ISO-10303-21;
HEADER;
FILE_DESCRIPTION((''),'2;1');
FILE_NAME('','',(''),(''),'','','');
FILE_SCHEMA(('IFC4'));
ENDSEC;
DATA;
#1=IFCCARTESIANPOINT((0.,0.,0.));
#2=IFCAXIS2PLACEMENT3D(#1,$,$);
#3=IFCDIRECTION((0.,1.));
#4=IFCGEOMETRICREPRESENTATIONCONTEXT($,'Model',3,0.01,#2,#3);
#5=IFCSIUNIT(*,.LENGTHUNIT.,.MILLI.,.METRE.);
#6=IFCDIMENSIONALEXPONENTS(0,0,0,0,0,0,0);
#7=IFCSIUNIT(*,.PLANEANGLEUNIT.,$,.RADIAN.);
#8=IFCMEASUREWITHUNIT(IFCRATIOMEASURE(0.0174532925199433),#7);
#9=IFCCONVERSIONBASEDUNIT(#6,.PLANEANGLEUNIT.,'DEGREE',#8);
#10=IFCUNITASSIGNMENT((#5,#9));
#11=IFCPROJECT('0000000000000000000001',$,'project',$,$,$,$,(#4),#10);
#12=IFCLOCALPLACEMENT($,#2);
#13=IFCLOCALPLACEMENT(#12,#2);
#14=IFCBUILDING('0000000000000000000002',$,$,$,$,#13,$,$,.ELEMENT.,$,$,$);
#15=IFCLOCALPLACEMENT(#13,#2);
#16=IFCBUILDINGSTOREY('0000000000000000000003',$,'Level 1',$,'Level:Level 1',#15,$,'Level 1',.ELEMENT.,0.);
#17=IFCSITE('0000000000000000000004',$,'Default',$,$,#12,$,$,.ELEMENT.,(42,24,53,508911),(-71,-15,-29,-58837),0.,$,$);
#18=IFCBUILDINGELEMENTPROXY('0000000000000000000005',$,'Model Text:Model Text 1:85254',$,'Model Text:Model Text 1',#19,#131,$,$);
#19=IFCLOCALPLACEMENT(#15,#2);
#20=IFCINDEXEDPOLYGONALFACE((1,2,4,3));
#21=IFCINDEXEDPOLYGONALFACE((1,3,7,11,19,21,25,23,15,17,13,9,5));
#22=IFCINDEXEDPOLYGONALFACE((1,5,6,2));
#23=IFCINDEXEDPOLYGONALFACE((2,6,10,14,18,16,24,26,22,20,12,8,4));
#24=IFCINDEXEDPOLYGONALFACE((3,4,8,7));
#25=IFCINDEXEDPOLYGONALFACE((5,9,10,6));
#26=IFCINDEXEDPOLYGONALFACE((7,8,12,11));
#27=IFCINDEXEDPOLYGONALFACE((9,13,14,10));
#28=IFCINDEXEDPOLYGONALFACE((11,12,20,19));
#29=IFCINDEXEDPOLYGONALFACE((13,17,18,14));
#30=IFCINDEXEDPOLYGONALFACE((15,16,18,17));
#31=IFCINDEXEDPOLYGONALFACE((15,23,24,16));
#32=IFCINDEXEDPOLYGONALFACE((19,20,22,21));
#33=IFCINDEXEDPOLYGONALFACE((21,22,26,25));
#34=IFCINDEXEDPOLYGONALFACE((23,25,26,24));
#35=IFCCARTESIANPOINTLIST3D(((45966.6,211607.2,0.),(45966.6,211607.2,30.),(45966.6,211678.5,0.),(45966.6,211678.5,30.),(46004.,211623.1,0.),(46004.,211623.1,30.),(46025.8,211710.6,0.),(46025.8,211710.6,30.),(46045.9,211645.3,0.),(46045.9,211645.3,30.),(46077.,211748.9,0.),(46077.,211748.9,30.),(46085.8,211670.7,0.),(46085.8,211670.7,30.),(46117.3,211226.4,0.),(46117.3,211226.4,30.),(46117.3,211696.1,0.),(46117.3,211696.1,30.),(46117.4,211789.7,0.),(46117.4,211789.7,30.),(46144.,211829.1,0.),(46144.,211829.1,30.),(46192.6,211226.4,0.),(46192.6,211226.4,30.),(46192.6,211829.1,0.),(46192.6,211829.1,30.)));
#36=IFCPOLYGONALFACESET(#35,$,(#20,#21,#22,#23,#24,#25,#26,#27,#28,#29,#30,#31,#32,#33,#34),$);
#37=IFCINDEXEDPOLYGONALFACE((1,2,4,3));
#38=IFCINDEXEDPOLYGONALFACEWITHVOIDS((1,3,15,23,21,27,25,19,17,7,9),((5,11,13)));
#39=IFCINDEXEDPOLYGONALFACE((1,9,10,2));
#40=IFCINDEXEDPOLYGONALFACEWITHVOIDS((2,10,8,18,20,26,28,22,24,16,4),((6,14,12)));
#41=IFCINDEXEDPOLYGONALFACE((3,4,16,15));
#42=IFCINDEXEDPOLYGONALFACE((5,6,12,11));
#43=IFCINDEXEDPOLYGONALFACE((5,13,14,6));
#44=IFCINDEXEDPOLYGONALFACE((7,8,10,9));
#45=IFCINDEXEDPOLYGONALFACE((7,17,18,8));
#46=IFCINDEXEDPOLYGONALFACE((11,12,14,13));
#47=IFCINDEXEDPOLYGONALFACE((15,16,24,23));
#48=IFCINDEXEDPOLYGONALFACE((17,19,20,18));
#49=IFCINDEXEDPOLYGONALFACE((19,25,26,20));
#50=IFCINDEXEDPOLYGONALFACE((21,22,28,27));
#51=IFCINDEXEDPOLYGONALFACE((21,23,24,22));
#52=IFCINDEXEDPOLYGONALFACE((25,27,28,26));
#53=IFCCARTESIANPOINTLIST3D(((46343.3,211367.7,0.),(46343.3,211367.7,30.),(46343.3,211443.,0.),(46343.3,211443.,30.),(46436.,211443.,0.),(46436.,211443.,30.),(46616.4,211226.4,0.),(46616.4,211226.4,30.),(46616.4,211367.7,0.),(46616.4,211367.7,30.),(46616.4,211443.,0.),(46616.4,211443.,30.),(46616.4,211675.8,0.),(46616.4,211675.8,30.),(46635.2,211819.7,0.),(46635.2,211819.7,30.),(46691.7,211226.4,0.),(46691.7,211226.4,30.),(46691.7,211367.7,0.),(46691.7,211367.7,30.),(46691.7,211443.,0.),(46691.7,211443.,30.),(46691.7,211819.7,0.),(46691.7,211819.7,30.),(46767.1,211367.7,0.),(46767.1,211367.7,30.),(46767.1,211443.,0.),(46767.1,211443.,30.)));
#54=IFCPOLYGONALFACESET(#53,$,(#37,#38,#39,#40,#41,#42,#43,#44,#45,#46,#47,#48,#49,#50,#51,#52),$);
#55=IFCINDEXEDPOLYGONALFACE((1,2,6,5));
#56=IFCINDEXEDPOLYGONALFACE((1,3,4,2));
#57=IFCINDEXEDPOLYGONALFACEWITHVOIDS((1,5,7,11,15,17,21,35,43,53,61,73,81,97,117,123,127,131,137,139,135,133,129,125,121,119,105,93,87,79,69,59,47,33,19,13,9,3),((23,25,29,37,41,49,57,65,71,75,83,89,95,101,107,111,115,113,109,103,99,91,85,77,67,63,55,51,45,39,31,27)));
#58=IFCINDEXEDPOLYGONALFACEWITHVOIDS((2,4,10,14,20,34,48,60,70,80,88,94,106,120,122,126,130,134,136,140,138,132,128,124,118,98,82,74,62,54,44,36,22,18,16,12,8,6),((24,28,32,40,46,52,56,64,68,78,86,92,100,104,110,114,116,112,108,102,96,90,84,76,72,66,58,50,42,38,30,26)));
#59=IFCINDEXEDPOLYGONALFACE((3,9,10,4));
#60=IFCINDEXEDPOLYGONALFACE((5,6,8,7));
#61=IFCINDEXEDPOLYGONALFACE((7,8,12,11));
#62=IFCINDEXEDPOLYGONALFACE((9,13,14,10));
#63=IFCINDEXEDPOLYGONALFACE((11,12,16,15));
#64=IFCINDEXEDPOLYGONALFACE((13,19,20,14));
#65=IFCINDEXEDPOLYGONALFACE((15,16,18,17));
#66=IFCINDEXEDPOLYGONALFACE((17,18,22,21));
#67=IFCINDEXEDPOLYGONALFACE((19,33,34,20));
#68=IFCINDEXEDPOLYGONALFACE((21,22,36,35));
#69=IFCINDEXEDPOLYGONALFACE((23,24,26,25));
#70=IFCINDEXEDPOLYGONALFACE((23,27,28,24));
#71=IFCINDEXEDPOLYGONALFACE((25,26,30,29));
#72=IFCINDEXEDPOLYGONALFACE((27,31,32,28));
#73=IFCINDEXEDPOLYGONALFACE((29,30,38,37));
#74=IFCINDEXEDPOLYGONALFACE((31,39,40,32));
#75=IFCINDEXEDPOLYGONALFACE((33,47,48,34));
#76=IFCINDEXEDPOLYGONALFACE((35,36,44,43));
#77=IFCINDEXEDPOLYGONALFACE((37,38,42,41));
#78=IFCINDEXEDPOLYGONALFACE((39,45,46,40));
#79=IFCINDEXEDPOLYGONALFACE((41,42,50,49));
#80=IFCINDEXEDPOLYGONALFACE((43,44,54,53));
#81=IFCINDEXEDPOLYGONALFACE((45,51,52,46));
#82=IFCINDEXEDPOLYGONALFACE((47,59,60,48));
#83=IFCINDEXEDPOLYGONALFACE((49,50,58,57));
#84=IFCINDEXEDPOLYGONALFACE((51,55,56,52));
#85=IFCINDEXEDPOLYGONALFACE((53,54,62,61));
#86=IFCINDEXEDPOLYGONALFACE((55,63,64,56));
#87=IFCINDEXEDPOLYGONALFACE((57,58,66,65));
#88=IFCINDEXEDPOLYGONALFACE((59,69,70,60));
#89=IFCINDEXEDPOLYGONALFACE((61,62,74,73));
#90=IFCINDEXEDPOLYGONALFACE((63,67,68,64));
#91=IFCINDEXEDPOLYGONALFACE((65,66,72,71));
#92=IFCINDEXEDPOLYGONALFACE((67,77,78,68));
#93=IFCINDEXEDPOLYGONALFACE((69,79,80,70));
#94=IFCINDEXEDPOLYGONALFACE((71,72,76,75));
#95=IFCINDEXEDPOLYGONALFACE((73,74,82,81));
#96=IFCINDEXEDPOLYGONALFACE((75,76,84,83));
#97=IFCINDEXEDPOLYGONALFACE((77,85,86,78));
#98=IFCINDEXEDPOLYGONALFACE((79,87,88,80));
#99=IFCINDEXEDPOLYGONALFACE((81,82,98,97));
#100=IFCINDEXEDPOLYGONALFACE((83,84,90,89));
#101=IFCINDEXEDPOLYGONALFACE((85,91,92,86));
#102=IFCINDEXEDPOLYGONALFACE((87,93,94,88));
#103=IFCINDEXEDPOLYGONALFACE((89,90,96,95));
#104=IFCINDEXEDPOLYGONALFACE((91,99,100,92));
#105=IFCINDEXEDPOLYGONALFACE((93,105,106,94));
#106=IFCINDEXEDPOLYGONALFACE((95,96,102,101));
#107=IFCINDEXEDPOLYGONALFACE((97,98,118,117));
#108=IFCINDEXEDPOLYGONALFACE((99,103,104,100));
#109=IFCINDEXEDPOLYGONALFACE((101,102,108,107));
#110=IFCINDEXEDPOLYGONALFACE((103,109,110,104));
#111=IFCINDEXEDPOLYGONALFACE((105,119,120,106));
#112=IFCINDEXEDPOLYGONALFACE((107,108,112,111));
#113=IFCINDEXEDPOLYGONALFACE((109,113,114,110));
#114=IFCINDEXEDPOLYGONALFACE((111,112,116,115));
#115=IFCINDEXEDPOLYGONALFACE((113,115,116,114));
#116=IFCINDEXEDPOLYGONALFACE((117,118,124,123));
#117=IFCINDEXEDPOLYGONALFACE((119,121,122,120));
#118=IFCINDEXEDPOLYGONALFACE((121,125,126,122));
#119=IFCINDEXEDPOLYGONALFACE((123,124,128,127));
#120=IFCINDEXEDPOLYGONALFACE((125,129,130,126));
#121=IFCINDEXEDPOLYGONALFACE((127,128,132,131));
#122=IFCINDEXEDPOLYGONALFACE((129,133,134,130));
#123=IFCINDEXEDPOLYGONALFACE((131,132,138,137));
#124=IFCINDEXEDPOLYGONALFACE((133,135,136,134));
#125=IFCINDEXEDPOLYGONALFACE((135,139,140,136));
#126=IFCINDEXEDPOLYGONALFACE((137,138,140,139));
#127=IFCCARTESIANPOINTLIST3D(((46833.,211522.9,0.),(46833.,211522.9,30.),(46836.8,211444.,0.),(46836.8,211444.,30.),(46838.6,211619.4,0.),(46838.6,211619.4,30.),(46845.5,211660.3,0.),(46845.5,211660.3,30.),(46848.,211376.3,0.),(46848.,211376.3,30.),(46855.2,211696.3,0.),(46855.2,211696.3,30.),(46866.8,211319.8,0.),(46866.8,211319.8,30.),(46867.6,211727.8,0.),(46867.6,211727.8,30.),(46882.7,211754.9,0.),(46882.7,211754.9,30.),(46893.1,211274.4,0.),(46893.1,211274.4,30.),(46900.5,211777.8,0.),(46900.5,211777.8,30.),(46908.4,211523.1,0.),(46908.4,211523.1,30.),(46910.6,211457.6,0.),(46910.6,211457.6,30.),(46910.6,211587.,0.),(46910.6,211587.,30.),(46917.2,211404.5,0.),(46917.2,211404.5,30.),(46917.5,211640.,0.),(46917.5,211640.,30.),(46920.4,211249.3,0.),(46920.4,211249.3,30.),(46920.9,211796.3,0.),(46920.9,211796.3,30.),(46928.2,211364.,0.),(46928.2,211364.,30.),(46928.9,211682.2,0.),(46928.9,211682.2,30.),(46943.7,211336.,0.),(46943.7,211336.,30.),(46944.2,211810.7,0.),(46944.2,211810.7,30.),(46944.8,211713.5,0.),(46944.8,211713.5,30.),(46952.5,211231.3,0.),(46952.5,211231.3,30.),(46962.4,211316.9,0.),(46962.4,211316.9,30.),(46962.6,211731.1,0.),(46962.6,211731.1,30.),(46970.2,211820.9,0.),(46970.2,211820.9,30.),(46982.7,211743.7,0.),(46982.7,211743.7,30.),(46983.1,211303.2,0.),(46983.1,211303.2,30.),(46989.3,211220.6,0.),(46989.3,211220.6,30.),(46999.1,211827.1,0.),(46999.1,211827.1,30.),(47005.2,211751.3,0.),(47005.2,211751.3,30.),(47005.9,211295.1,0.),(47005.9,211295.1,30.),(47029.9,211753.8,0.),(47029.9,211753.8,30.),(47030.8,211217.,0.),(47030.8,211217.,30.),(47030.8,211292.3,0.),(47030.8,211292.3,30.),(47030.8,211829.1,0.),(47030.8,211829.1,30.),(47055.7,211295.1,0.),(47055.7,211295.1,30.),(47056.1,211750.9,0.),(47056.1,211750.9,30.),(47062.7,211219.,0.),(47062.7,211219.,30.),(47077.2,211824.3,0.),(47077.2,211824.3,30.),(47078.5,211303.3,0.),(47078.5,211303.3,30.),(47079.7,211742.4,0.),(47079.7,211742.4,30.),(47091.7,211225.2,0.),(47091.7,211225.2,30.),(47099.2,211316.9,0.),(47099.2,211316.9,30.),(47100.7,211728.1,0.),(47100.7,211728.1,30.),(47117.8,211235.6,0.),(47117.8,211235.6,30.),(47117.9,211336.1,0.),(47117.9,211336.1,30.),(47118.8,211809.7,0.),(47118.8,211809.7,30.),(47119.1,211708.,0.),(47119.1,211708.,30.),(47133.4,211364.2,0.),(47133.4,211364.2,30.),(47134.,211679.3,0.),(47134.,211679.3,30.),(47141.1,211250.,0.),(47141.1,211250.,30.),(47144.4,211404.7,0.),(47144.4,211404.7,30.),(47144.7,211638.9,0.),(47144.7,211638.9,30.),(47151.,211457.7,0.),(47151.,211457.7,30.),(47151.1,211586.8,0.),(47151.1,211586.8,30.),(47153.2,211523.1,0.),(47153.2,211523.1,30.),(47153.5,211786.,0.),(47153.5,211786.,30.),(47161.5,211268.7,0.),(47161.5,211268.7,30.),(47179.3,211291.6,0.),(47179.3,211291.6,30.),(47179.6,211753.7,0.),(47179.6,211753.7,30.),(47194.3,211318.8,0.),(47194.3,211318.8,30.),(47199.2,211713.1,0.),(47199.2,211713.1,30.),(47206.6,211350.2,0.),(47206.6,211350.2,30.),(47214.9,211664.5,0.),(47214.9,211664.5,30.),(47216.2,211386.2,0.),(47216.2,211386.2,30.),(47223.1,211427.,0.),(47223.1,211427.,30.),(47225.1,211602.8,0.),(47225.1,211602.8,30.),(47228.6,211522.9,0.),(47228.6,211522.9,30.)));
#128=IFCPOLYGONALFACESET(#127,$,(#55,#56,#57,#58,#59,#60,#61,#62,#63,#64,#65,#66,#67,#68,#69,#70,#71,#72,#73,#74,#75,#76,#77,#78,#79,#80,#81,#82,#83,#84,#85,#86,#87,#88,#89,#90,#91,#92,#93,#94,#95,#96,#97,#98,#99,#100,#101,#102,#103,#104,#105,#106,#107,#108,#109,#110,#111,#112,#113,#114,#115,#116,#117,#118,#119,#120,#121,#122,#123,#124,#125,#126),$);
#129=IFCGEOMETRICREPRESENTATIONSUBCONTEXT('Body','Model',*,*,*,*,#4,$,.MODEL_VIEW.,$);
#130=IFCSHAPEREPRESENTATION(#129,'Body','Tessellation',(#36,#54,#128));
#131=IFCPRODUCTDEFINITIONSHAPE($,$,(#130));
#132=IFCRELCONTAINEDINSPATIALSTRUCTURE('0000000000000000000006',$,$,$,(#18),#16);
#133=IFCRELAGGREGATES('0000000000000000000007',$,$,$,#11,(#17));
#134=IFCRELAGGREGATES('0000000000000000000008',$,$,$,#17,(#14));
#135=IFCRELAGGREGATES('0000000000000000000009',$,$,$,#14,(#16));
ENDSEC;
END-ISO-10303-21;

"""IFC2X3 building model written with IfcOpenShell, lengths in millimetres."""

from ifc_helpers import new_model, entity, si_unit, converted_unit, direction, frame, origin, place, context, subcontext, project, spatial, polyline, outline, extrude, element, save


model = new_model("IFC2X3")

# Units and contexts
model_context = context("Model", 3, precision=0.01, world=origin(), true_north=direction((0.0, 1.0)))
body_context = subcontext(model_context, "Body", "Model", "MODEL_VIEW")
ifc_project = project(units=[si_unit("LENGTHUNIT", "METRE", prefix="MILLI"), converted_unit("PLANEANGLEUNIT", "DEGREE", entity("IfcRatioMeasure", 0.0174532925199433), si_unit("PLANEANGLEUNIT", "RADIAN"), dimensions=[0, 0, 0, 0, 0, 0, 0])], contexts=[model_context])

# Site, building, storey
site_placement = place(None, origin())
site = spatial("IfcSite", under=ifc_project, at=site_placement, Name="Default", CompositionType="ELEMENT", RefLatitude=(42, 24, 53, 508911), RefLongitude=(-71, -15, -29, -58837), RefElevation=0.0)
building_placement = place(site_placement, origin())
building = spatial("IfcBuilding", under=site, at=building_placement, CompositionType="ELEMENT")
storey_placement = place(building_placement, origin())
storey = spatial("IfcBuildingStorey", under=building, at=storey_placement, Name="Level 1", ObjectType="Level:Level 1", LongName="Level 1", CompositionType="ELEMENT", Elevation=0.0)

# Building element proxy
proxy_1_placement = place(storey_placement, origin())
element("IfcBuildingElementProxy", 1, at=proxy_1_placement, inside=storey, Name="Model Text:Model Text 1:85254", ObjectType="Model Text:Model Text 1", context=body_context, shape_type="SweptSolid", body=[
    extrude(outline(polyline([(-410.6, -111.6), (192.1, -111.6), (192.1, -63.1), (152.7, -36.4), (111.9, 4.0), (73.6, 55.2), (41.4, 114.4), (-29.8, 114.4), (-13.9, 77.0), (8.3, 35.1), (33.7, -4.8), (59.1, -36.3), (-410.6, -36.3), (-410.6, -111.6)])), frame((46081.0, 211637.0, 0.0), z_axis=(0.0, 0.0, 1.0), x_axis=(0.0, 1.0, 0.0)), (0.0, 0.0, 1.0), 30.0),
    extrude(outline(polyline([(-6.8, -218.3), (68.5, -218.3), (68.5, -77.1), (143.8, -77.1), (143.8, -1.7), (68.5, -1.7), (68.5, 375.0), (12.0, 375.0), (-280.0, -1.7), (-280.0, -77.1), (-6.8, -77.1), (-6.8, -218.3)]), holes=[polyline([(-6.8, -1.7), (-187.3, -1.7), (-6.8, 231.1), (-6.8, -1.7)])]), frame((46623.3, 211444.7, 0.0)), (0.0, 0.0, 1.0), 30.0),
    extrude(outline(polyline([(-10.6, -198.7), (68.3, -198.7), (136.5, -190.7), (193.9, -174.7), (240.5, -150.6), (266.9, -124.4), (286.3, -93.2), (298.8, -57.0), (304.3, -15.7), (303.8, 16.2), (299.0, 45.5), (289.9, 72.1), (276.6, 96.0), (258.9, 117.3), (236.9, 136.2), (210.4, 152.5), (179.6, 166.3), (144.1, 177.6), (103.7, 186.3), (8.2, 196.4), (-71.8, 196.7), (-134.0, 189.4), (-183.3, 176.1), (-224.7, 158.4), (-258.2, 133.9), (-283.5, 100.3), (-300.1, 59.5), (-307.1, 13.4), (-306.6, -18.4), (-301.8, -47.5), (-292.8, -74.0), (-279.6, -97.9), (-262.0, -119.2), (-240.0, -138.1), (-213.6, -154.5), (-182.8, -168.4), (-147.3, -179.8), (-106.7, -188.6), (-10.6, -198.7)]), holes=[polyline([(-7.2, -123.5), (-71.0, -118.2), (-123.6, -108.8), (-165.2, -95.4), (-195.7, -78.0), (-212.4, -59.4), (-224.1, -38.7), (-230.6, -15.9), (-231.9, 8.9), (-227.8, 35.0), (-218.1, 58.1), (-202.8, 78.4), (-182.0, 95.8), (-152.6, 109.4), (-111.7, 118.1), (-59.4, 122.0), (4.4, 121.1), (69.6, 115.8), (122.2, 106.7), (162.2, 93.7), (189.5, 77.0), (207.7, 57.4), (220.4, 36.0), (227.5, 12.8), (229.1, -12.1), (225.2, -36.8), (215.9, -59.2), (201.3, -79.3), (181.4, -97.1), (152.6, -111.2), (111.6, -120.3), (58.3, -124.4), (-7.2, -123.5)])]), frame((47032.0, 211521.7, 0.0), z_axis=(0.0, 0.0, 1.0), x_axis=(0.047515, -0.998871, 0.0)), (0.0, 0.0, 1.0), 30.0),
])

save(model, "model.ifc")
